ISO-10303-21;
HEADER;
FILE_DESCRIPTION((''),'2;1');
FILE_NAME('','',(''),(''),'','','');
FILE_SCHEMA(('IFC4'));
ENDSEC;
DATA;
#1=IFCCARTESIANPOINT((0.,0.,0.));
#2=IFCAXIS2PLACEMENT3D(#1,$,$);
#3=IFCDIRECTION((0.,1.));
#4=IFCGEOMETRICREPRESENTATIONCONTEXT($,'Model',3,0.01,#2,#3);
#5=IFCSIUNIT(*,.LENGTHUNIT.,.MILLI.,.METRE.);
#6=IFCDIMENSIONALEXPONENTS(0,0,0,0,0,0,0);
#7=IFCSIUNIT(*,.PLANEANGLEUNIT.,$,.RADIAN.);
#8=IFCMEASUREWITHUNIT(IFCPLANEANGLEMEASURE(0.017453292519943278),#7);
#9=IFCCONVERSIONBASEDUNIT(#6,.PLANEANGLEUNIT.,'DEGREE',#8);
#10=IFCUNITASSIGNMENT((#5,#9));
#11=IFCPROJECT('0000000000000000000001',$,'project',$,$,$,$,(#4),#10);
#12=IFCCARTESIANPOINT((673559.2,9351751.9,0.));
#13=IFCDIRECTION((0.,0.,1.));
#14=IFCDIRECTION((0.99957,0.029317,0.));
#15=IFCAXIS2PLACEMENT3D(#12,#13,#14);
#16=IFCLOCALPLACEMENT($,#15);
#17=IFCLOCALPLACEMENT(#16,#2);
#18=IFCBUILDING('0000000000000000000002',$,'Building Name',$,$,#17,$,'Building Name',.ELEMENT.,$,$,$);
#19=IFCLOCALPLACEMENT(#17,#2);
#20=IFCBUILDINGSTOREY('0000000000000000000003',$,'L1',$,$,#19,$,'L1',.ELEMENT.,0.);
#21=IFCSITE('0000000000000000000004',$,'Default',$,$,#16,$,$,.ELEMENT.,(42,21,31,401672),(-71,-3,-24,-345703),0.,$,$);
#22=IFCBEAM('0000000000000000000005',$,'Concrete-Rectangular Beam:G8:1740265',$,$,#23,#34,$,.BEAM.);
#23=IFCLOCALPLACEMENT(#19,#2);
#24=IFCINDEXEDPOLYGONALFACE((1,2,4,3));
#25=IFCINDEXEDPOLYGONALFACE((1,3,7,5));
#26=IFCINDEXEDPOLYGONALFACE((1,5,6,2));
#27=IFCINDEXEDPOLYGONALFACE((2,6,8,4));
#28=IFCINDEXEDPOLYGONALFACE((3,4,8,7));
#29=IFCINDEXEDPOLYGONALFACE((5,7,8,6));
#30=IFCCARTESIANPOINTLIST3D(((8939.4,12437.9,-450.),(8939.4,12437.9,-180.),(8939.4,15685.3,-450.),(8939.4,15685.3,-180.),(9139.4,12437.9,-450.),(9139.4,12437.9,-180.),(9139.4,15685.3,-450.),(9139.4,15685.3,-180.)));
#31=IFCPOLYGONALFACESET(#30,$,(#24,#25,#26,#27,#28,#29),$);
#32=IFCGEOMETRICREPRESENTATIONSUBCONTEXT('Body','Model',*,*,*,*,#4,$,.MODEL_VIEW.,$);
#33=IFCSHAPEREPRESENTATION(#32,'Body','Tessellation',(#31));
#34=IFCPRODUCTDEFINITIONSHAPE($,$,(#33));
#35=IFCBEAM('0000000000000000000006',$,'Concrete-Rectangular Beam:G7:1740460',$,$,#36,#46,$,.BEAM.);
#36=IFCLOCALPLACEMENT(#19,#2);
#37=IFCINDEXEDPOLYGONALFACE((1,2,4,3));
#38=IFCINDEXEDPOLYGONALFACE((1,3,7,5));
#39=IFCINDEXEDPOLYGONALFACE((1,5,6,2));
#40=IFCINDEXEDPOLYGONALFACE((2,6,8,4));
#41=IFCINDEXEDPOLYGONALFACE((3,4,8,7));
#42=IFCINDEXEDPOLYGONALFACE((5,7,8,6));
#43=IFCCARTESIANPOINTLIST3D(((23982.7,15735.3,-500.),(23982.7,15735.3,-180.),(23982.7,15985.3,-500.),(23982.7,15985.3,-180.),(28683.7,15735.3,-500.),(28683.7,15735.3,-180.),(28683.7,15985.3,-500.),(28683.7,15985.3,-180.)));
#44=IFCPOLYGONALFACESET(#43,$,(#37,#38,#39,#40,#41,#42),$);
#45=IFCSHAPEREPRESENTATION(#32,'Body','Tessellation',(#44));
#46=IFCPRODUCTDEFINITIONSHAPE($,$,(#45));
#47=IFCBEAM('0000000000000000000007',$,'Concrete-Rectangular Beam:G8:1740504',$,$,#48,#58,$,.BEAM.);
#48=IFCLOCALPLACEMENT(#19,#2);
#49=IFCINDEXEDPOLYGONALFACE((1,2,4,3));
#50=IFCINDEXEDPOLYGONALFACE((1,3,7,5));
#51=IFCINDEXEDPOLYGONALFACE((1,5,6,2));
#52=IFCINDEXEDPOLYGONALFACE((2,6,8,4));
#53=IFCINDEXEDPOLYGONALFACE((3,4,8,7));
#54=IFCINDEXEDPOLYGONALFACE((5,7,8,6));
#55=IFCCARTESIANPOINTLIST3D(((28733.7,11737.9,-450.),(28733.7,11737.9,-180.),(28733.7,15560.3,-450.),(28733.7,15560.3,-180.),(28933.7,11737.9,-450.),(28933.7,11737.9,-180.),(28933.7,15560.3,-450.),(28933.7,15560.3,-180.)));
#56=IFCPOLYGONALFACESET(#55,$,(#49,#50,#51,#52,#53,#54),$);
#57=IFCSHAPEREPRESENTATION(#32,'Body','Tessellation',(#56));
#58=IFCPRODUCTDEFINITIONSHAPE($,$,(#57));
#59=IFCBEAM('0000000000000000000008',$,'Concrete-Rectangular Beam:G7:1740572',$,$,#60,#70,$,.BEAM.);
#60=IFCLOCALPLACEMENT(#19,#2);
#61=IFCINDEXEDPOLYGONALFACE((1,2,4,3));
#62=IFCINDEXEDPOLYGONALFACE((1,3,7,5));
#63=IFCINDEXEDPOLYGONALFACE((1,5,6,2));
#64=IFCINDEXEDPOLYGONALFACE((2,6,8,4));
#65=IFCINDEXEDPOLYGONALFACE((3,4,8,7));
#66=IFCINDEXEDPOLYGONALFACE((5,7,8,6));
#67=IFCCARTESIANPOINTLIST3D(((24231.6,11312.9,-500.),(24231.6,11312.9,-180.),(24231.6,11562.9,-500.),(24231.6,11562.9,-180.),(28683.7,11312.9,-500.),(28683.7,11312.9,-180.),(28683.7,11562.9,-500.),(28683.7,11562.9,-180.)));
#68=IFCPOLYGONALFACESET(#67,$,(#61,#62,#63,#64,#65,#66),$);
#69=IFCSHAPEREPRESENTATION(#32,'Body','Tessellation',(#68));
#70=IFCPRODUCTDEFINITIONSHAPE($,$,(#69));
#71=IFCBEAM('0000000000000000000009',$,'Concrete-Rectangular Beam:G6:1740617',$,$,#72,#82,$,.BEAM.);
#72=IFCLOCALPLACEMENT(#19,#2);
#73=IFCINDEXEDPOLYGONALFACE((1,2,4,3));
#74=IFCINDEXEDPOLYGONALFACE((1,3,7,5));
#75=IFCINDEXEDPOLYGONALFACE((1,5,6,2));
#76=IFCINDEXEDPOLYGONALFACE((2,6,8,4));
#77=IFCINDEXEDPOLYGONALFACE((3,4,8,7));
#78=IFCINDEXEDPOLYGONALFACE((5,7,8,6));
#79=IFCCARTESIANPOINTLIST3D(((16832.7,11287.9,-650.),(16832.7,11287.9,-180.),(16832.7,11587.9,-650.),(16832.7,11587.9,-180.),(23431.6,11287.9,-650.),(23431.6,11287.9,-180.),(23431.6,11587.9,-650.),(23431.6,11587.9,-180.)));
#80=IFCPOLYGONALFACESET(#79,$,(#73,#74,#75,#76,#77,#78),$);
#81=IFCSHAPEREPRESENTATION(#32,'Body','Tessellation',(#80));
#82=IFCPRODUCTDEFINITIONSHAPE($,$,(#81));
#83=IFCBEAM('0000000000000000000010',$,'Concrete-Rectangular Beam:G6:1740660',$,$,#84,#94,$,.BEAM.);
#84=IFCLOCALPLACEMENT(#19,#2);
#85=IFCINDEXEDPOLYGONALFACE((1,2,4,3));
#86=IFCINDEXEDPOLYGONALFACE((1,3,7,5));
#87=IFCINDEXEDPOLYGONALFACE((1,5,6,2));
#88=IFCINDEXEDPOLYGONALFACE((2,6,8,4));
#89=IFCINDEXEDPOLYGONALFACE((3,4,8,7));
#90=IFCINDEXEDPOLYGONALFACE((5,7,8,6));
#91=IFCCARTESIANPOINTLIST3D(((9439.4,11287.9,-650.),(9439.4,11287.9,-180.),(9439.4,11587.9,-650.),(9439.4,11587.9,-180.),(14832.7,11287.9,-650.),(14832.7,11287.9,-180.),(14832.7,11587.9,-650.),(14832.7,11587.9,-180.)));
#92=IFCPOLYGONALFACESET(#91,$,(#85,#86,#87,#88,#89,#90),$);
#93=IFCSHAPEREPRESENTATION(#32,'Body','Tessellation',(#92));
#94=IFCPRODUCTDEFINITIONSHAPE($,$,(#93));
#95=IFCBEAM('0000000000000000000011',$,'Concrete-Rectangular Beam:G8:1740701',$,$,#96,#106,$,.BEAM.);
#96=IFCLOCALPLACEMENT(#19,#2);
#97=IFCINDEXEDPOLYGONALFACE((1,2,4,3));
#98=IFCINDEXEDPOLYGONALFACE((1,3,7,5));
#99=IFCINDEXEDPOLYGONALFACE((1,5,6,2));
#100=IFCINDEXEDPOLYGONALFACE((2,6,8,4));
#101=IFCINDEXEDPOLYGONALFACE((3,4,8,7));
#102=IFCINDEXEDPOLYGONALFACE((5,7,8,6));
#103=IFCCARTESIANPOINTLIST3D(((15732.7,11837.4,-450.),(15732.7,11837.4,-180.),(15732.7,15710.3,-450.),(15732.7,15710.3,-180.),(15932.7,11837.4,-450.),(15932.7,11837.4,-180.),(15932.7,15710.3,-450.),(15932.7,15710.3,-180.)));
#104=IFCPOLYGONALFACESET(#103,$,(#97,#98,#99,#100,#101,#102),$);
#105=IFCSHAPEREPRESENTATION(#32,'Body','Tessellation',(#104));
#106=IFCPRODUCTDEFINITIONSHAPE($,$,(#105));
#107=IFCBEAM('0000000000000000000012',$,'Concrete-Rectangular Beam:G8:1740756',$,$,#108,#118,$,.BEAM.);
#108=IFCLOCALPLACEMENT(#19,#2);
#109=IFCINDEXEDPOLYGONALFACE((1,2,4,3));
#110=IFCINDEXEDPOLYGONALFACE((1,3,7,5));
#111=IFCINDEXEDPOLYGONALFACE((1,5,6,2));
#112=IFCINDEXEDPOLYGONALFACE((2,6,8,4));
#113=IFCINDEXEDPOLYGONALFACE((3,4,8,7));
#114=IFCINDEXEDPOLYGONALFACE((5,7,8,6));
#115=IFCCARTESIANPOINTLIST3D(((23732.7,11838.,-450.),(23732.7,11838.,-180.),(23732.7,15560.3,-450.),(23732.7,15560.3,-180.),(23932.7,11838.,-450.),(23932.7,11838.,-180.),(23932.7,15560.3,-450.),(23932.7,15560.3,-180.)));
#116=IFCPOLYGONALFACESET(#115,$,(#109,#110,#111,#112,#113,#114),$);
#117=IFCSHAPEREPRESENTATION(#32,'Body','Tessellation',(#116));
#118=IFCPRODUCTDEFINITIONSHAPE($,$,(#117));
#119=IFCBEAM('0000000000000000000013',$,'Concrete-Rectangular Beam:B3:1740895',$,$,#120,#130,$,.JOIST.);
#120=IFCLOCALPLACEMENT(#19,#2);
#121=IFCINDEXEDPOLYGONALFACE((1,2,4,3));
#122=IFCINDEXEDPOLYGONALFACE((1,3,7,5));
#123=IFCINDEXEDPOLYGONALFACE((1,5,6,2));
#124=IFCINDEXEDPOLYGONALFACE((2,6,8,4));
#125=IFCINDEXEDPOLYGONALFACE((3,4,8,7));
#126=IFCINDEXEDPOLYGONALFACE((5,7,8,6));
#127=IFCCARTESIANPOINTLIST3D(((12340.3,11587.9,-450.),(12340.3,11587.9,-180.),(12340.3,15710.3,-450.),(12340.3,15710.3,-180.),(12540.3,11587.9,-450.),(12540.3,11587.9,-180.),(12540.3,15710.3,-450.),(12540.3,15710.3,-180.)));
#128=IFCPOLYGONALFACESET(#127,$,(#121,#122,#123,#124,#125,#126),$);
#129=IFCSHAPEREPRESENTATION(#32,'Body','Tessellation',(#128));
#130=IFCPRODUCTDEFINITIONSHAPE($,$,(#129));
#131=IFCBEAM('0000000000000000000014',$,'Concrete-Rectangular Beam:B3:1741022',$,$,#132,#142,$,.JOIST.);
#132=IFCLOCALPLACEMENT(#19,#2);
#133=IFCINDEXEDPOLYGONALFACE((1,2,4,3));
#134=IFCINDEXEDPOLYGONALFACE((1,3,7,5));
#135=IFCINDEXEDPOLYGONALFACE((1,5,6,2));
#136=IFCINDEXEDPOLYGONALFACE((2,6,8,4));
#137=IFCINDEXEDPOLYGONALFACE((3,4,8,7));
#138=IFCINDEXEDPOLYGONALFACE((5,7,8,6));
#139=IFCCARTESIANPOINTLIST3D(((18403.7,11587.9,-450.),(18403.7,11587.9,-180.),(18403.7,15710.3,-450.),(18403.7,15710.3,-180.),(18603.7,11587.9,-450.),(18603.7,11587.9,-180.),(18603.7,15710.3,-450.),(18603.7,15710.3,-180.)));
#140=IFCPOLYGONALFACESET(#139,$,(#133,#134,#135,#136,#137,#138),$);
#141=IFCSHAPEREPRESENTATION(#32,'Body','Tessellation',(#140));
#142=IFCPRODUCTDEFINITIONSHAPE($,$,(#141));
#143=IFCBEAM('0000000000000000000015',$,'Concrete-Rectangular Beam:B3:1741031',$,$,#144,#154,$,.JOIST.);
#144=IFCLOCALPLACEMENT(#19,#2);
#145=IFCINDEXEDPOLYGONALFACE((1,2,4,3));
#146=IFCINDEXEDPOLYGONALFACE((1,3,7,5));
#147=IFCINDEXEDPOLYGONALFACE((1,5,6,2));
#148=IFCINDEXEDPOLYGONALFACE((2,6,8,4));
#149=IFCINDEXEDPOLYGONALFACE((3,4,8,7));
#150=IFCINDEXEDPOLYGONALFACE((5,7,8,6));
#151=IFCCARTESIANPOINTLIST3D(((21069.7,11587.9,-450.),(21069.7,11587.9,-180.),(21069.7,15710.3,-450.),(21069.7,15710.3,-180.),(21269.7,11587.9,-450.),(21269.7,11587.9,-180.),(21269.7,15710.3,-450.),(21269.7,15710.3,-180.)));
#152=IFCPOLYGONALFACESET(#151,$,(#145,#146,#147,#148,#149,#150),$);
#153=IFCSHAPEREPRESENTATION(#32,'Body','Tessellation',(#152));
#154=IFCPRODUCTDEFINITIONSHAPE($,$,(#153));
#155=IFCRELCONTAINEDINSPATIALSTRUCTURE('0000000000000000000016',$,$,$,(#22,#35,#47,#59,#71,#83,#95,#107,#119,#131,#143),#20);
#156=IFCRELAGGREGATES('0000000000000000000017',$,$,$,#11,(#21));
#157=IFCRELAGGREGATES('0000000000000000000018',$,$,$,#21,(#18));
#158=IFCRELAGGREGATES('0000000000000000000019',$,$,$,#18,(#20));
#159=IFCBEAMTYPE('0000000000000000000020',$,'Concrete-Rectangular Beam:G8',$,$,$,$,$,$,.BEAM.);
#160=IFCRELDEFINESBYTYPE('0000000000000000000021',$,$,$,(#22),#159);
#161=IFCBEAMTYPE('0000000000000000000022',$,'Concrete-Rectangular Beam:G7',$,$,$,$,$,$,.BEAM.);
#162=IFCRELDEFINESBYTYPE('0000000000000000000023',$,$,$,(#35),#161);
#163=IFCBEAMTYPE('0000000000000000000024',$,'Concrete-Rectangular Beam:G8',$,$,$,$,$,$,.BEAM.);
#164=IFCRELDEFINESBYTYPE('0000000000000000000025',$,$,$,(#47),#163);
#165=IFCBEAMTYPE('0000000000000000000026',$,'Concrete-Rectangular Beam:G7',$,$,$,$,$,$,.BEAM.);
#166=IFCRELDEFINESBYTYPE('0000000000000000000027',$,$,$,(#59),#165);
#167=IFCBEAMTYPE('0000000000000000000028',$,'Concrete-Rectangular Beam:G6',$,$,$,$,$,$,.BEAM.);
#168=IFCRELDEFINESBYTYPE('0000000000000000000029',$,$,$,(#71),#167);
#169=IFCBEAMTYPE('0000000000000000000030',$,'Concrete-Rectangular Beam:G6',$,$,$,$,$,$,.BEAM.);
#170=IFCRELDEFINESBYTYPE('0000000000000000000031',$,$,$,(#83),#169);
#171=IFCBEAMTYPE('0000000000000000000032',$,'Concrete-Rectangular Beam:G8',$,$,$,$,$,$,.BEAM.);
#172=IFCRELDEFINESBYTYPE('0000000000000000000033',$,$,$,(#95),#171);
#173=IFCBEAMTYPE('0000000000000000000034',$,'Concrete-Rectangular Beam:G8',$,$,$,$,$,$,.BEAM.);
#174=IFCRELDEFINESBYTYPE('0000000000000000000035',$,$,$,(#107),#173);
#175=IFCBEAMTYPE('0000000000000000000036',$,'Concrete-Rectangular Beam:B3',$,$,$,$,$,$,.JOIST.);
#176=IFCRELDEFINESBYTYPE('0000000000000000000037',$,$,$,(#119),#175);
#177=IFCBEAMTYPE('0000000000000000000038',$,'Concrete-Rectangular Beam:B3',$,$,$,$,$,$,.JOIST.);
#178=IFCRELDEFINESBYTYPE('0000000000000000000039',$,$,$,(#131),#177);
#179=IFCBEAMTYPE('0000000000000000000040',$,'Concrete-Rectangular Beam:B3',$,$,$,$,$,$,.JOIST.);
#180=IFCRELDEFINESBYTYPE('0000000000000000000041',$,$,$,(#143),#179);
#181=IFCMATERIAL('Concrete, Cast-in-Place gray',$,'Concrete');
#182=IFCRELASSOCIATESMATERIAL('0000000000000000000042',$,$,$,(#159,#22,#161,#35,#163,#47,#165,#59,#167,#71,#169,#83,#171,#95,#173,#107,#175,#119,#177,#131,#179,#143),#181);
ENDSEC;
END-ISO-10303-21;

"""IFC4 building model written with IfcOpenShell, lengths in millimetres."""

from ifc_helpers import new_model, entity, si_unit, converted_unit, direction, frame, origin, place, context, subcontext, project, spatial, indexed_curve, outline, extrude, source, transform, mapped, material, type_object, type_shapes, element, save


model = new_model("IFC4")

# Units and contexts
model_context = context("Model", 3, precision=0.01, world=origin(), true_north=direction((0.0, 1.0)))
body_context = subcontext(model_context, "Body", "Model", "MODEL_VIEW")
ifc_project = project(units=[si_unit("LENGTHUNIT", "METRE", prefix="MILLI"), converted_unit("PLANEANGLEUNIT", "DEGREE", entity("IfcPlaneAngleMeasure", 0.017453292519943278), si_unit("PLANEANGLEUNIT", "RADIAN"), dimensions=[0, 0, 0, 0, 0, 0, 0])], contexts=[model_context])

# Site, building, storey
site_placement = place(None, frame((673559.2, 9351751.9, 0.0), z_axis=(0.0, 0.0, 1.0), x_axis=(0.99957, 0.029317, 0.0)))
site = spatial("IfcSite", under=ifc_project, at=site_placement, Name="Default", CompositionType="ELEMENT", RefLatitude=(42, 21, 31, 401672), RefLongitude=(-71, -3, -24, -345703), RefElevation=0.0)
building_placement = place(site_placement, origin())
building = spatial("IfcBuilding", under=site, at=building_placement, Name="Building Name", LongName="Building Name", CompositionType="ELEMENT")
storey_placement = place(building_placement, origin())
storey = spatial("IfcBuildingStorey", under=building, at=storey_placement, Name="L1", LongName="L1", CompositionType="ELEMENT", Elevation=0.0)

# Beams
ifc_material = material(Name="Concrete, Cast-in-Place gray", Category="Concrete")
beam_type_1 = type_object("IfcBeamType", Name="Concrete-Rectangular Beam:G8", PredefinedType="BEAM", material=ifc_material)
shared_shape_1 = source(origin(), body_context, "Body", "SweptSolid", [
    extrude(outline(indexed_curve([(-100.0, -135.0), (100.0, -135.0), (100.0, 135.0), (-100.0, 135.0), (-100.0, -135.0)], self_intersect=False)), frame((9039.4, 12437.9, -315.0), z_axis=(0.0, 1.0, 0.0), x_axis=(-1.0, 0.0, 0.0)), (0.0, 0.0, 1.0), 3247.4),
])
type_shapes(beam_type_1, [shared_shape_1])
beam_1_placement = place(storey_placement, origin())
element("IfcBeam", 1, at=beam_1_placement, inside=storey, type_object=beam_type_1, material=ifc_material, Name="Concrete-Rectangular Beam:G8:1740265", PredefinedType="BEAM", context=body_context, shape_type="MappedRepresentation", body=[
    mapped(shared_shape_1, transform((0.0, 0.0, 0.0), scale=1.0)),
])
beam_type_2 = type_object("IfcBeamType", Name="Concrete-Rectangular Beam:G7", PredefinedType="BEAM", material=ifc_material)
shared_shape_2 = source(origin(), body_context, "Body", "SweptSolid", [
    extrude(outline(indexed_curve([(-160.0, -125.0), (160.0, -125.0), (160.0, 125.0), (-160.0, 125.0), (-160.0, -125.0)], self_intersect=False)), frame((23982.7, 15860.3, -340.0), z_axis=(1.0, 0.0, 0.0), x_axis=(0.0, 0.0, -1.0)), (0.0, 0.0, 1.0), 4701.0),
])
type_shapes(beam_type_2, [shared_shape_2])
beam_2_placement = place(storey_placement, origin())
element("IfcBeam", 2, at=beam_2_placement, inside=storey, type_object=beam_type_2, material=ifc_material, Name="Concrete-Rectangular Beam:G7:1740460", PredefinedType="BEAM", context=body_context, shape_type="MappedRepresentation", body=[
    mapped(shared_shape_2, transform((0.0, 0.0, 0.0), scale=1.0)),
])
beam_type_3 = type_object("IfcBeamType", Name="Concrete-Rectangular Beam:G8", PredefinedType="BEAM", material=ifc_material)
shared_shape_3 = source(origin(), body_context, "Body", "SweptSolid", [
    extrude(outline(indexed_curve([(-100.0, -135.0), (100.0, -135.0), (100.0, 135.0), (-100.0, 135.0), (-100.0, -135.0)], self_intersect=False)), frame((28833.7, 15560.3, -315.0), z_axis=(0.0, -1.0, 0.0), x_axis=(-1.0, 0.0, 0.0)), (0.0, 0.0, 1.0), 3822.4),
])
type_shapes(beam_type_3, [shared_shape_3])
beam_3_placement = place(storey_placement, origin())
element("IfcBeam", 3, at=beam_3_placement, inside=storey, type_object=beam_type_3, material=ifc_material, Name="Concrete-Rectangular Beam:G8:1740504", PredefinedType="BEAM", context=body_context, shape_type="MappedRepresentation", body=[
    mapped(shared_shape_3, transform((0.0, 0.0, 0.0), scale=1.0)),
])
beam_type_4 = type_object("IfcBeamType", Name="Concrete-Rectangular Beam:G7", PredefinedType="BEAM", material=ifc_material)
shared_shape_4 = source(origin(), body_context, "Body", "SweptSolid", [
    extrude(outline(indexed_curve([(-160.0, -125.0), (160.0, -125.0), (160.0, 125.0), (-160.0, 125.0), (-160.0, -125.0)], self_intersect=False)), frame((28683.7, 11437.9, -340.0), z_axis=(-1.0, 0.0, 0.0), x_axis=(0.0, 0.0, -1.0)), (0.0, 0.0, 1.0), 4452.1),
])
type_shapes(beam_type_4, [shared_shape_4])
beam_4_placement = place(storey_placement, origin())
element("IfcBeam", 4, at=beam_4_placement, inside=storey, type_object=beam_type_4, material=ifc_material, Name="Concrete-Rectangular Beam:G7:1740572", PredefinedType="BEAM", context=body_context, shape_type="MappedRepresentation", body=[
    mapped(shared_shape_4, transform((0.0, 0.0, 0.0), scale=1.0)),
])
beam_type_5 = type_object("IfcBeamType", Name="Concrete-Rectangular Beam:G6", PredefinedType="BEAM", material=ifc_material)
shared_shape_5 = source(origin(), body_context, "Body", "SweptSolid", [
    extrude(outline(indexed_curve([(-235.0, -150.0), (235.0, -150.0), (235.0, 150.0), (-235.0, 150.0), (-235.0, -150.0)], self_intersect=False)), frame((23431.6, 11437.9, -415.0), z_axis=(-1.0, 0.0, 0.0), x_axis=(0.0, 0.0, -1.0)), (0.0, 0.0, 1.0), 6599.0),
])
type_shapes(beam_type_5, [shared_shape_5])
beam_5_placement = place(storey_placement, origin())
element("IfcBeam", 5, at=beam_5_placement, inside=storey, type_object=beam_type_5, material=ifc_material, Name="Concrete-Rectangular Beam:G6:1740617", PredefinedType="BEAM", context=body_context, shape_type="MappedRepresentation", body=[
    mapped(shared_shape_5, transform((0.0, 0.0, 0.0), scale=1.0)),
])
beam_type_6 = type_object("IfcBeamType", Name="Concrete-Rectangular Beam:G6", PredefinedType="BEAM", material=ifc_material)
shared_shape_6 = source(origin(), body_context, "Body", "SweptSolid", [
    extrude(outline(indexed_curve([(-235.0, -150.0), (235.0, -150.0), (235.0, 150.0), (-235.0, 150.0), (-235.0, -150.0)], self_intersect=False)), frame((14832.7, 11437.9, -415.0), z_axis=(-1.0, 0.0, 0.0), x_axis=(0.0, 0.0, -1.0)), (0.0, 0.0, 1.0), 5393.3),
])
type_shapes(beam_type_6, [shared_shape_6])
beam_6_placement = place(storey_placement, origin())
element("IfcBeam", 6, at=beam_6_placement, inside=storey, type_object=beam_type_6, material=ifc_material, Name="Concrete-Rectangular Beam:G6:1740660", PredefinedType="BEAM", context=body_context, shape_type="MappedRepresentation", body=[
    mapped(shared_shape_6, transform((0.0, 0.0, 0.0), scale=1.0)),
])
beam_type_7 = type_object("IfcBeamType", Name="Concrete-Rectangular Beam:G8", PredefinedType="BEAM", material=ifc_material)
shared_shape_7 = source(origin(), body_context, "Body", "SweptSolid", [
    extrude(outline(indexed_curve([(-100.0, -135.0), (100.0, -135.0), (100.0, 135.0), (-100.0, 135.0), (-100.0, -135.0)], self_intersect=False)), frame((15832.7, 15710.3, -315.0), z_axis=(0.0, -1.0, 0.0), x_axis=(-1.0, 0.0, 0.0)), (0.0, 0.0, 1.0), 3872.9),
])
type_shapes(beam_type_7, [shared_shape_7])
beam_7_placement = place(storey_placement, origin())
element("IfcBeam", 7, at=beam_7_placement, inside=storey, type_object=beam_type_7, material=ifc_material, Name="Concrete-Rectangular Beam:G8:1740701", PredefinedType="BEAM", context=body_context, shape_type="MappedRepresentation", body=[
    mapped(shared_shape_7, transform((0.0, 0.0, 0.0), scale=1.0)),
])
beam_type_8 = type_object("IfcBeamType", Name="Concrete-Rectangular Beam:G8", PredefinedType="BEAM", material=ifc_material)
shared_shape_8 = source(origin(), body_context, "Body", "SweptSolid", [
    extrude(outline(indexed_curve([(-100.0, -135.0), (100.0, -135.0), (100.0, 135.0), (-100.0, 135.0), (-100.0, -135.0)], self_intersect=False)), frame((23832.7, 15560.3, -315.0), z_axis=(0.0, -1.0, 0.0), x_axis=(-1.0, 0.0, 0.0)), (0.0, 0.0, 1.0), 3722.3),
])
type_shapes(beam_type_8, [shared_shape_8])
beam_8_placement = place(storey_placement, origin())
element("IfcBeam", 8, at=beam_8_placement, inside=storey, type_object=beam_type_8, material=ifc_material, Name="Concrete-Rectangular Beam:G8:1740756", PredefinedType="BEAM", context=body_context, shape_type="MappedRepresentation", body=[
    mapped(shared_shape_8, transform((0.0, 0.0, 0.0), scale=1.0)),
])
beam_type_9 = type_object("IfcBeamType", Name="Concrete-Rectangular Beam:B3", PredefinedType="JOIST", material=ifc_material)
shared_shape_9 = source(origin(), body_context, "Body", "SweptSolid", [
    extrude(outline(indexed_curve([(-100.0, -135.0), (100.0, -135.0), (100.0, 135.0), (-100.0, 135.0), (-100.0, -135.0)], self_intersect=False)), frame((12440.3, 15710.3, -315.0), z_axis=(0.0, -1.0, 0.0), x_axis=(-1.0, 0.0, 0.0)), (0.0, 0.0, 1.0), 4122.4),
])
type_shapes(beam_type_9, [shared_shape_9])
beam_9_placement = place(storey_placement, origin())
element("IfcBeam", 9, at=beam_9_placement, inside=storey, type_object=beam_type_9, material=ifc_material, Name="Concrete-Rectangular Beam:B3:1740895", PredefinedType="JOIST", context=body_context, shape_type="MappedRepresentation", body=[
    mapped(shared_shape_9, transform((0.0, 0.0, 0.0), scale=1.0)),
])
beam_type_10 = type_object("IfcBeamType", Name="Concrete-Rectangular Beam:B3", PredefinedType="JOIST", material=ifc_material)
shared_shape_10 = source(origin(), body_context, "Body", "SweptSolid", [
    extrude(outline(indexed_curve([(-100.0, -135.0), (100.0, -135.0), (100.0, 135.0), (-100.0, 135.0), (-100.0, -135.0)], self_intersect=False)), frame((18503.7, 15710.3, -315.0), z_axis=(0.0, -1.0, 0.0), x_axis=(-1.0, 0.0, 0.0)), (0.0, 0.0, 1.0), 4122.4),
])
type_shapes(beam_type_10, [shared_shape_10])
beam_10_placement = place(storey_placement, origin())
element("IfcBeam", 10, at=beam_10_placement, inside=storey, type_object=beam_type_10, material=ifc_material, Name="Concrete-Rectangular Beam:B3:1741022", PredefinedType="JOIST", context=body_context, shape_type="MappedRepresentation", body=[
    mapped(shared_shape_10, transform((0.0, 0.0, 0.0), scale=1.0)),
])
beam_type_11 = type_object("IfcBeamType", Name="Concrete-Rectangular Beam:B3", PredefinedType="JOIST", material=ifc_material)
shared_shape_11 = source(origin(), body_context, "Body", "SweptSolid", [
    extrude(outline(indexed_curve([(-100.0, -135.0), (100.0, -135.0), (100.0, 135.0), (-100.0, 135.0), (-100.0, -135.0)], self_intersect=False)), frame((21169.7, 15710.3, -315.0), z_axis=(0.0, -1.0, 0.0), x_axis=(-1.0, 0.0, 0.0)), (0.0, 0.0, 1.0), 4122.4),
])
type_shapes(beam_type_11, [shared_shape_11])
beam_11_placement = place(storey_placement, origin())
element("IfcBeam", 11, at=beam_11_placement, inside=storey, type_object=beam_type_11, material=ifc_material, Name="Concrete-Rectangular Beam:B3:1741031", PredefinedType="JOIST", context=body_context, shape_type="MappedRepresentation", body=[
    mapped(shared_shape_11, transform((0.0, 0.0, 0.0), scale=1.0)),
])

save(model, "model.ifc")
